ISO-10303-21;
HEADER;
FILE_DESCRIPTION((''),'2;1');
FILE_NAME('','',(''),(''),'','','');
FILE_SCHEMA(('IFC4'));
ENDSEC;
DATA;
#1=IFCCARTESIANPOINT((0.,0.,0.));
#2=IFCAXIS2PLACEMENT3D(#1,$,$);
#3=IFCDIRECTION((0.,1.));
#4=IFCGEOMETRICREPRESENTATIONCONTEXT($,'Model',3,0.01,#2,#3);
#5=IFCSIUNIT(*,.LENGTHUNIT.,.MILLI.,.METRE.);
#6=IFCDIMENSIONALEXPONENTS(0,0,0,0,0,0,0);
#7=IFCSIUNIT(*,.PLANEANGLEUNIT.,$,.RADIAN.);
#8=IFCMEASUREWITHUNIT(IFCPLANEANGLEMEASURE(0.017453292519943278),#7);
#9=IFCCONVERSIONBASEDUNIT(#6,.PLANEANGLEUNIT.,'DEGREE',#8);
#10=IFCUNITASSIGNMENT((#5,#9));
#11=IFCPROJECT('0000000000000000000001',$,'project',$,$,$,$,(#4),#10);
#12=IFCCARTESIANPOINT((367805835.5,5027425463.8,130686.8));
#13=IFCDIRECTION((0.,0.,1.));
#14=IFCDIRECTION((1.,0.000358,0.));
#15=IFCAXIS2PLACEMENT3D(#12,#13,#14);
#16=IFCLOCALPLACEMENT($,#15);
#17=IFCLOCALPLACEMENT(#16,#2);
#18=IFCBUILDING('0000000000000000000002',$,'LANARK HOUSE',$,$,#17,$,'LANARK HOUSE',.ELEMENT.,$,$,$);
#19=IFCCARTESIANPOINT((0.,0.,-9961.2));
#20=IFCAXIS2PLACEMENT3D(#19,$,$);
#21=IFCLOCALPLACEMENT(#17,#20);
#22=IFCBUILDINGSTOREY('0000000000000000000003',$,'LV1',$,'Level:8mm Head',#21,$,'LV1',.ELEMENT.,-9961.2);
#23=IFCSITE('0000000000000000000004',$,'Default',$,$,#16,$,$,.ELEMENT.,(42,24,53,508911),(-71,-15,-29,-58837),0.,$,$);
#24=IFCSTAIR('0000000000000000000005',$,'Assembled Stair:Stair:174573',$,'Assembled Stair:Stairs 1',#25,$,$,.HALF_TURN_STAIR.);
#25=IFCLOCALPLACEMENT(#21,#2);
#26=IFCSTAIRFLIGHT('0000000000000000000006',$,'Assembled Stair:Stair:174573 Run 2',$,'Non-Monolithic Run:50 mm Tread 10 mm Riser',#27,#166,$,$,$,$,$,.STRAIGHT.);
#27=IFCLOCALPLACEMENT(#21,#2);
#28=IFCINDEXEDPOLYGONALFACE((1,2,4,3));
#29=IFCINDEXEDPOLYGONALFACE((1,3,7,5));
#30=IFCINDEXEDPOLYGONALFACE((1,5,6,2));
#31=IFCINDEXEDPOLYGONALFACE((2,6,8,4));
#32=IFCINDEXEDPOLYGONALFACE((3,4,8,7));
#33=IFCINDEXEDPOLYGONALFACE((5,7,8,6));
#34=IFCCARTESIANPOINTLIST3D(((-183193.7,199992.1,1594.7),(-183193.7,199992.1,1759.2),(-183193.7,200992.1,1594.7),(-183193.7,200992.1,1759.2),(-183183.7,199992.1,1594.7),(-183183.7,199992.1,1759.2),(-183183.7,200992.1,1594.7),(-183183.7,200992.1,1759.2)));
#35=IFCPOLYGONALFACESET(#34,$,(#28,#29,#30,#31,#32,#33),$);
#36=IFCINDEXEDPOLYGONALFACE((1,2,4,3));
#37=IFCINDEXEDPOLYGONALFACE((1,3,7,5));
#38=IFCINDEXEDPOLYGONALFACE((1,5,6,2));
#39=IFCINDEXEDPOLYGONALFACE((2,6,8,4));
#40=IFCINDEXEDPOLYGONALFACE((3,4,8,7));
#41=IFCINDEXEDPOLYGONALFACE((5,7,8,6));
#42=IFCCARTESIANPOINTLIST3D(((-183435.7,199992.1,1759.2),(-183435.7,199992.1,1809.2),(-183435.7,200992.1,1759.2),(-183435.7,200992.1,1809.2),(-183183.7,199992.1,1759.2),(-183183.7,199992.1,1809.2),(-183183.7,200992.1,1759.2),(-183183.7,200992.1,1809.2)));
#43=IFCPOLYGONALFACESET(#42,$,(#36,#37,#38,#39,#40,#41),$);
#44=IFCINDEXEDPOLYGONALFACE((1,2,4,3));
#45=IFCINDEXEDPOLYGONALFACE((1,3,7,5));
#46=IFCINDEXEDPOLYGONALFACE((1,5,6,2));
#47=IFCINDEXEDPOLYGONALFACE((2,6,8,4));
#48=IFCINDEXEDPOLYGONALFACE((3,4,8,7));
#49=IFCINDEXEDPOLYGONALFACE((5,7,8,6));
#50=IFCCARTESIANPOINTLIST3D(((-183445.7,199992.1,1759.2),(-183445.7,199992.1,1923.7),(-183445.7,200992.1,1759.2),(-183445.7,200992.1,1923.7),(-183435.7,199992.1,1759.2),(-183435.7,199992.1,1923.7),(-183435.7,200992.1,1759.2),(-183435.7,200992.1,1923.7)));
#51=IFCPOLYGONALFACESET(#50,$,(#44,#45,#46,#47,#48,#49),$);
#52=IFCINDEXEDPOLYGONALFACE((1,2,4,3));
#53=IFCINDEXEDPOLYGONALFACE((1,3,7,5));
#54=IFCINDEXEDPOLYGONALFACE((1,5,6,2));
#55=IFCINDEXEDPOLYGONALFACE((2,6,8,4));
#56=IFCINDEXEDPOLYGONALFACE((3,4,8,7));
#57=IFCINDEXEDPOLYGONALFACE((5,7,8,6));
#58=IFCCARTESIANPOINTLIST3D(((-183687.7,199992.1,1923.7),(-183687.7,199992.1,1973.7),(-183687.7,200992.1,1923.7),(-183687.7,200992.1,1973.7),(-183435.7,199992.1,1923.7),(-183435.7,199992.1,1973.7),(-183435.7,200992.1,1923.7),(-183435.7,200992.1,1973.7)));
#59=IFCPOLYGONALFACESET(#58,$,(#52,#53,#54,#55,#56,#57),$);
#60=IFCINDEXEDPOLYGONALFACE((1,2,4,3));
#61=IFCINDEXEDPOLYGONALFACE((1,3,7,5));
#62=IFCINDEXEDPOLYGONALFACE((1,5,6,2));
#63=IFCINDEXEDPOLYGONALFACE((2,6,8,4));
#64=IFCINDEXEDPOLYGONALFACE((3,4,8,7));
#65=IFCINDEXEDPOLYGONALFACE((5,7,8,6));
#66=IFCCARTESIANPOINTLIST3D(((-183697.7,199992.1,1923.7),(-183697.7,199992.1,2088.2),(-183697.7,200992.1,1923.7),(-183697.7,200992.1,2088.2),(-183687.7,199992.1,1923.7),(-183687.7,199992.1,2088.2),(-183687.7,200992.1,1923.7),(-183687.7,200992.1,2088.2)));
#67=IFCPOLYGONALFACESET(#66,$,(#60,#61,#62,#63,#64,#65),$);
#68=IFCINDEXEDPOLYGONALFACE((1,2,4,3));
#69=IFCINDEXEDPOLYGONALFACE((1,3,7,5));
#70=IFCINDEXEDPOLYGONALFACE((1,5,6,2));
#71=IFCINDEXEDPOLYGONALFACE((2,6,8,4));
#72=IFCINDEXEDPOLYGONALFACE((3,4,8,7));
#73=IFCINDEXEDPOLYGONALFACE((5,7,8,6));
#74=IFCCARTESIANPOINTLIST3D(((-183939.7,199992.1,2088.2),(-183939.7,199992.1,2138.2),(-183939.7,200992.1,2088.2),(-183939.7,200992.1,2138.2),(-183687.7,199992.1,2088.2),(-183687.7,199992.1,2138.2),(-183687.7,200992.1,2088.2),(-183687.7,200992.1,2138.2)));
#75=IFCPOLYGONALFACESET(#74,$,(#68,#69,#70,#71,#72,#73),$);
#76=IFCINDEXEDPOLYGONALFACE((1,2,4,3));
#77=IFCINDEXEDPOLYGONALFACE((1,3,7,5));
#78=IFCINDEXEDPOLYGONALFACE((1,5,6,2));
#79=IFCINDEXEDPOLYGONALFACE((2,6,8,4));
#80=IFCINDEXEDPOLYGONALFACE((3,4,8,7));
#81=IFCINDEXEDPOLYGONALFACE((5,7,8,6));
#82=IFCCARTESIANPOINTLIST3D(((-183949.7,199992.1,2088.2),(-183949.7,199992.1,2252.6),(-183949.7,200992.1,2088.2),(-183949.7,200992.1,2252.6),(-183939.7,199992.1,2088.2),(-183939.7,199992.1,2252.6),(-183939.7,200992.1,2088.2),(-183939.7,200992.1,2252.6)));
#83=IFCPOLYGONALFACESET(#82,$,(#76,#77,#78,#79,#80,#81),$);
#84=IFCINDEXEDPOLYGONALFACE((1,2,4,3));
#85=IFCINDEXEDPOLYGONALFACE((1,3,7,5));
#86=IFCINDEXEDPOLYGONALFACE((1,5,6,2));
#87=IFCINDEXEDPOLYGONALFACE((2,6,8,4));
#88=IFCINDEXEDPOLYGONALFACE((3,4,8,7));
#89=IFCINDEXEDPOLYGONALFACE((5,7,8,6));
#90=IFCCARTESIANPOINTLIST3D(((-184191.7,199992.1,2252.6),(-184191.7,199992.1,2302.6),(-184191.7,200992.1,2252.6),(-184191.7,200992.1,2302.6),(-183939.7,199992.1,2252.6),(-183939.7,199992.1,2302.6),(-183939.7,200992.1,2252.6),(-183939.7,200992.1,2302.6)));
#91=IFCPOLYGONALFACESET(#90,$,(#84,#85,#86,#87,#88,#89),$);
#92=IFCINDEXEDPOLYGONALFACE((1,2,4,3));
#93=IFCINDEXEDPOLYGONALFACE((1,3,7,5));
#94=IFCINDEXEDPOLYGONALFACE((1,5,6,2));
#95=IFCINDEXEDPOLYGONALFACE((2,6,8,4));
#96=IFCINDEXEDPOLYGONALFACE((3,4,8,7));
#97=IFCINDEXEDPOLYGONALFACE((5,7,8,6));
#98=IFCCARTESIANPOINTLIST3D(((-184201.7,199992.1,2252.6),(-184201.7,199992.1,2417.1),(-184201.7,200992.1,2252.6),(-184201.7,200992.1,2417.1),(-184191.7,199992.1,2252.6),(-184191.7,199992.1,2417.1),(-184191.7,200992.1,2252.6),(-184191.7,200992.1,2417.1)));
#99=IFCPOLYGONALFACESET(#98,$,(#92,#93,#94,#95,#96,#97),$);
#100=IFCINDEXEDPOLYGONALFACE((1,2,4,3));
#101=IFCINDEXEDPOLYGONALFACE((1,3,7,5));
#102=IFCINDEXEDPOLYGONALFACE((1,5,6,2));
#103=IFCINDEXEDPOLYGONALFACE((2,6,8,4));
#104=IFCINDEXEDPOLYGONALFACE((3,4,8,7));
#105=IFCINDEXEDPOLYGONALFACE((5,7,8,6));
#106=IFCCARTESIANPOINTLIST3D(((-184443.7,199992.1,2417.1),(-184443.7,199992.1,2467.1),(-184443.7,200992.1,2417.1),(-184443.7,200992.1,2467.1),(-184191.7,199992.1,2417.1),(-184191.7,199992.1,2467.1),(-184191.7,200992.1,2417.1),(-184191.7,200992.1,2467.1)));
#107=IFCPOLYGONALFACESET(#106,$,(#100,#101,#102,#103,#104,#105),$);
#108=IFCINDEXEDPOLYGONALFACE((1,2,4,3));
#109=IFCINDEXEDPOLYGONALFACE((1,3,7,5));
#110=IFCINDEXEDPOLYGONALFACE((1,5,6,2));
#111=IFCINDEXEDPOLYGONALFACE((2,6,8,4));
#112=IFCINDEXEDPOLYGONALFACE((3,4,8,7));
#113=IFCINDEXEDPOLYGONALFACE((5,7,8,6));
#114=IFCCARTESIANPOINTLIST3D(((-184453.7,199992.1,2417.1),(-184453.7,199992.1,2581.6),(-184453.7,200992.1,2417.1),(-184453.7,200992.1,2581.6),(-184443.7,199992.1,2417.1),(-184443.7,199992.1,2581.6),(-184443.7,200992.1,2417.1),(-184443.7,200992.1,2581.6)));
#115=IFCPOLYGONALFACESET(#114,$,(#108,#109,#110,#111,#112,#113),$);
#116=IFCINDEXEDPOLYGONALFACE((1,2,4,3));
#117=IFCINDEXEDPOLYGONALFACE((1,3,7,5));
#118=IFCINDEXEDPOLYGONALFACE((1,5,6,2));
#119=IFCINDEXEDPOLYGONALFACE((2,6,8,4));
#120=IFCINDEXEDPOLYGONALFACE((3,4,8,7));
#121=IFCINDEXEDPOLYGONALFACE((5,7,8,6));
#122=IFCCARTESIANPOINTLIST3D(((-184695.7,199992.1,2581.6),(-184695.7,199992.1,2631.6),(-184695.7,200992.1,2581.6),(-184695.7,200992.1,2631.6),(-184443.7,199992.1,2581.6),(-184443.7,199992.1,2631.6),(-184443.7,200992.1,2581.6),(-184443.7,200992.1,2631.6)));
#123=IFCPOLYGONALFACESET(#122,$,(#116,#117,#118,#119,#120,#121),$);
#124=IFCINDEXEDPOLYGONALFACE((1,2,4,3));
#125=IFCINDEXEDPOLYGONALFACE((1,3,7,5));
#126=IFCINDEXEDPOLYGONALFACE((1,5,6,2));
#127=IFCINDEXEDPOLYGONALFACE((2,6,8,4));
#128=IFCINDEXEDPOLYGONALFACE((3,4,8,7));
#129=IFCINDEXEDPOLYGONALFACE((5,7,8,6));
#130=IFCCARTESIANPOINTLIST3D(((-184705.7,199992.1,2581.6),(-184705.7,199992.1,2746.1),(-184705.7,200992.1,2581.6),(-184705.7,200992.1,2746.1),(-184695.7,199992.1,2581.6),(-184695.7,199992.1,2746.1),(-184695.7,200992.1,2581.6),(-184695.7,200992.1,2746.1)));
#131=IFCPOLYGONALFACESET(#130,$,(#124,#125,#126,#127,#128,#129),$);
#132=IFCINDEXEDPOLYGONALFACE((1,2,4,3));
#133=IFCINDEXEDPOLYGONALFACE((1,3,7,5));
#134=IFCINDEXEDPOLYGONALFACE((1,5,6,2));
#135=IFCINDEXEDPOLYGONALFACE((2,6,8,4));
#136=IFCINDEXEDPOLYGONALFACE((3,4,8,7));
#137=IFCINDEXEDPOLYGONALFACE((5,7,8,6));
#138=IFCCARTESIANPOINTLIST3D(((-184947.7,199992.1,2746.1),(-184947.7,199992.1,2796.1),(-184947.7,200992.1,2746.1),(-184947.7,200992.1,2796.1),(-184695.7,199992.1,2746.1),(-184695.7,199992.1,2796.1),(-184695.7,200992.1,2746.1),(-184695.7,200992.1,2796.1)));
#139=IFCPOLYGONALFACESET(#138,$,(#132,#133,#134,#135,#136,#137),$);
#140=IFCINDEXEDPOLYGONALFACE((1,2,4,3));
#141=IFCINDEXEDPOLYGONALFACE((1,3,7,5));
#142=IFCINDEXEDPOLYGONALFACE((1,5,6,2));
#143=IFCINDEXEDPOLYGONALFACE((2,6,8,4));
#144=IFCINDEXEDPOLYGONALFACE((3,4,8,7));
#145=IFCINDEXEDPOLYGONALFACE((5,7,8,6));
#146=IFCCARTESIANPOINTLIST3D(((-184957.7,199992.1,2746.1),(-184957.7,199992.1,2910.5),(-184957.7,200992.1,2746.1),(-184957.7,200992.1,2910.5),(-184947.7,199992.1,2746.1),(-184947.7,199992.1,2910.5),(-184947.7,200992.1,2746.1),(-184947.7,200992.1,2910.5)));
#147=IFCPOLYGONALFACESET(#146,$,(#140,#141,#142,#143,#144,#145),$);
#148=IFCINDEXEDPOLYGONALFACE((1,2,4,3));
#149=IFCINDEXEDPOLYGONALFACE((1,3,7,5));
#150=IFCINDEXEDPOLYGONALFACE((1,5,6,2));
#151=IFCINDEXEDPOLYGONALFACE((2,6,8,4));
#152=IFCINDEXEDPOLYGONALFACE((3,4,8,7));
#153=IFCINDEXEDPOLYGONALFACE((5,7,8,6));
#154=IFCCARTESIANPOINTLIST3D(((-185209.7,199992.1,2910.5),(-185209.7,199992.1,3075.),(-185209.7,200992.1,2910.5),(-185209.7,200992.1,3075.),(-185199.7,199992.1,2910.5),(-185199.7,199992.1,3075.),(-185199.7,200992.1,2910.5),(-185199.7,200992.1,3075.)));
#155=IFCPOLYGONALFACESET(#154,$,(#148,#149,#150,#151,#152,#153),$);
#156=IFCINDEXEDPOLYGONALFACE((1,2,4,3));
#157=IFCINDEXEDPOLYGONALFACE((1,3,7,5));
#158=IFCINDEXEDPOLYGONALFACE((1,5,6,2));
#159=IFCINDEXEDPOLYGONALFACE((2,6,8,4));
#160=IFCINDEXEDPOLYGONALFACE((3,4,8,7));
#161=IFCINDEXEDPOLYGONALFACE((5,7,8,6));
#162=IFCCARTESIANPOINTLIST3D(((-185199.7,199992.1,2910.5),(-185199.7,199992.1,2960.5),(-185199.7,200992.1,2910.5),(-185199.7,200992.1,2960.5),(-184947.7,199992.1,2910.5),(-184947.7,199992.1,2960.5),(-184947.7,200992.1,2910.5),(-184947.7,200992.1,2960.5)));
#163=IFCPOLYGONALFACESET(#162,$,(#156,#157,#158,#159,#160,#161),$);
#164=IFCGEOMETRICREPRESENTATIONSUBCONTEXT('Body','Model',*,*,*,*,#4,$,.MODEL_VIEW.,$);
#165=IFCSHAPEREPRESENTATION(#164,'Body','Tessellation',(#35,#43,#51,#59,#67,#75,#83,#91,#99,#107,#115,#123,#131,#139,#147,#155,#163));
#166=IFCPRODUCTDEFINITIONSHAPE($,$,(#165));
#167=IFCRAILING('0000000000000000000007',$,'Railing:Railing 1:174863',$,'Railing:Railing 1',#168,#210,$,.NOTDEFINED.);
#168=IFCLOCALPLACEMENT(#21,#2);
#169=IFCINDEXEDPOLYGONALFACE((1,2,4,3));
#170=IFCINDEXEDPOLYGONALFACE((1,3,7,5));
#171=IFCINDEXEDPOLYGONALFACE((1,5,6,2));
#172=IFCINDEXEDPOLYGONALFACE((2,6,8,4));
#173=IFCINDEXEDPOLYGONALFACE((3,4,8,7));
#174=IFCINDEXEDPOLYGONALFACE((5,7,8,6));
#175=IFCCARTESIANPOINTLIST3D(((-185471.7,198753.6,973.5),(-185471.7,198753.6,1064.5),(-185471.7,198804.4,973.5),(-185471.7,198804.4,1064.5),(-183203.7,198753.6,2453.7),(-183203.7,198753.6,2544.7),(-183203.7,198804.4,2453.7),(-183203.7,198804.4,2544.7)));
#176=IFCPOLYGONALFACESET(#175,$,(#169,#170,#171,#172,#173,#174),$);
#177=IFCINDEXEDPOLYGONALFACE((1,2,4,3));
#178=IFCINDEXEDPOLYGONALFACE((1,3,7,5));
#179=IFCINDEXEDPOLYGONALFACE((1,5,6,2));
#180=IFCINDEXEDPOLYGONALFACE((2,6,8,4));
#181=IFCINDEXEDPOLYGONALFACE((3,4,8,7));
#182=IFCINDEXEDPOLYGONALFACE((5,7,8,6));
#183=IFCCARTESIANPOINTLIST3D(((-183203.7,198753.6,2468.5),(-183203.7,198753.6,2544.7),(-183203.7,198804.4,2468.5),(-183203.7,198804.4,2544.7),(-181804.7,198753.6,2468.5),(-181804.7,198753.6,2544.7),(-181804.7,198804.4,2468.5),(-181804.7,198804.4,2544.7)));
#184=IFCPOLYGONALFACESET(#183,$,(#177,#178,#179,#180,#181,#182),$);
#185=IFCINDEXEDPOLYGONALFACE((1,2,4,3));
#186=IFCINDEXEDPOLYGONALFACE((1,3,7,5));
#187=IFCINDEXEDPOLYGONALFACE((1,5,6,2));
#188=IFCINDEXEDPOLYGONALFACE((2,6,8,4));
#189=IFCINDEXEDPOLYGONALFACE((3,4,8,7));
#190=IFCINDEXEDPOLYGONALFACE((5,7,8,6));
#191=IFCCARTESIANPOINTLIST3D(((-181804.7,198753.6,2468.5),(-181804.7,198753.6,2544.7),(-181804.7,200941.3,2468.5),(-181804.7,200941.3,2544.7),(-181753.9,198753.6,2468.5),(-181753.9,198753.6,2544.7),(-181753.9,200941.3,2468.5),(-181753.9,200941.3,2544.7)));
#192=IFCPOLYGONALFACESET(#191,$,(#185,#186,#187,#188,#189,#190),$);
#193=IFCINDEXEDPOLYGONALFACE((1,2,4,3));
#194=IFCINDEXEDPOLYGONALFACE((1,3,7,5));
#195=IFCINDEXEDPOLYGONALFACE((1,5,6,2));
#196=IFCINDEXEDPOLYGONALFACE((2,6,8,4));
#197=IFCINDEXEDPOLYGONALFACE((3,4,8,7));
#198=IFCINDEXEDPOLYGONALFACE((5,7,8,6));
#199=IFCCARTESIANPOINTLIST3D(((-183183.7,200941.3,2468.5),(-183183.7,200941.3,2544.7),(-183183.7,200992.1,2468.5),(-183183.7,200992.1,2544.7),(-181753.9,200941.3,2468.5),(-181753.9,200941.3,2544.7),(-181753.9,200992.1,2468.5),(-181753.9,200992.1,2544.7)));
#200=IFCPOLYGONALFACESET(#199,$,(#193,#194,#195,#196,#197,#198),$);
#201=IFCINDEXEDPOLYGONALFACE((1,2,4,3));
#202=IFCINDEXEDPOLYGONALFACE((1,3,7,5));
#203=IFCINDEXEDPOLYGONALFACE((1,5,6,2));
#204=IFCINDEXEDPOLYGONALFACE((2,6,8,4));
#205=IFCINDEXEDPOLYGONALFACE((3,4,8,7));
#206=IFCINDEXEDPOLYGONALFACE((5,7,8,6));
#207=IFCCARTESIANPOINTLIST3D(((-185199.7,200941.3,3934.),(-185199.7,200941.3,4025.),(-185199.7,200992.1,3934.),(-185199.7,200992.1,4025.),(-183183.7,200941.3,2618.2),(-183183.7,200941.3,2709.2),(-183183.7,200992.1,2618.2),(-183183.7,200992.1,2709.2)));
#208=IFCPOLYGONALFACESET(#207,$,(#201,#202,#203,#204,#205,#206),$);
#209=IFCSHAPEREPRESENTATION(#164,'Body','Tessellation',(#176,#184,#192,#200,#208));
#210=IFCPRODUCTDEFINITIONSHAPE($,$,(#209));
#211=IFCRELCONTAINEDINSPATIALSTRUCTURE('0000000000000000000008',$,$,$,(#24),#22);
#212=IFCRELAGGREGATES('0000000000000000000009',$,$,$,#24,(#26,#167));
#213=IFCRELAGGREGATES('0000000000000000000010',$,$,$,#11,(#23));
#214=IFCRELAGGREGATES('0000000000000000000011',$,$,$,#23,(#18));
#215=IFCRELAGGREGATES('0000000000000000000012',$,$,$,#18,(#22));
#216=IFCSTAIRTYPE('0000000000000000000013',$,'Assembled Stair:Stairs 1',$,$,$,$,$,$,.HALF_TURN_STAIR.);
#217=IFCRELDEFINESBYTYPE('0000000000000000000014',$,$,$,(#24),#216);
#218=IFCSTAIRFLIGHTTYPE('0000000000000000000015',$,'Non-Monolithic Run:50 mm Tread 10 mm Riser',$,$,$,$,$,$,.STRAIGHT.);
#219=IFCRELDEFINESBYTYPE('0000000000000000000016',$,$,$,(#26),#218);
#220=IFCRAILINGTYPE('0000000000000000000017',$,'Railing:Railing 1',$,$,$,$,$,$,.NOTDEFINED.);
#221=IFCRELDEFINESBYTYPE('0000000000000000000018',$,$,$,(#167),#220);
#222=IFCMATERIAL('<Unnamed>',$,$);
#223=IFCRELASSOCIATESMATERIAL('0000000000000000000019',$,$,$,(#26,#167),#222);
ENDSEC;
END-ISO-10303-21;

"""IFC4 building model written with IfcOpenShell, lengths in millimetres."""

from ifc_helpers import new_model, entity, si_unit, converted_unit, direction, frame, origin, place, context, subcontext, project, spatial, indexed_curve, outline, extrude, material, type_object, element, aggregate, save


model = new_model("IFC4")

# Units and contexts
model_context = context("Model", 3, precision=0.01, world=origin(), true_north=direction((0.0, 1.0)))
body_context = subcontext(model_context, "Body", "Model", "MODEL_VIEW")
ifc_project = project(units=[si_unit("LENGTHUNIT", "METRE", prefix="MILLI"), converted_unit("PLANEANGLEUNIT", "DEGREE", entity("IfcPlaneAngleMeasure", 0.017453292519943278), si_unit("PLANEANGLEUNIT", "RADIAN"), dimensions=[0, 0, 0, 0, 0, 0, 0])], contexts=[model_context])

# Site, building, storey
site_placement = place(None, frame((367805835.5, 5027425463.8, 130686.8), z_axis=(0.0, 0.0, 1.0), x_axis=(1.0, 0.000358, 0.0)))
site = spatial("IfcSite", under=ifc_project, at=site_placement, Name="Default", CompositionType="ELEMENT", RefLatitude=(42, 24, 53, 508911), RefLongitude=(-71, -15, -29, -58837), RefElevation=0.0)
building_placement = place(site_placement, origin())
building = spatial("IfcBuilding", under=site, at=building_placement, Name="LANARK HOUSE", LongName="LANARK HOUSE", CompositionType="ELEMENT")
storey_placement = place(building_placement, frame((0.0, 0.0, -9961.2)))
storey = spatial("IfcBuildingStorey", under=building, at=storey_placement, Name="LV1", ObjectType="Level:8mm Head", LongName="LV1", CompositionType="ELEMENT", Elevation=-9961.2)

# Stair
stair_type = type_object("IfcStairType", Name="Assembled Stair:Stairs 1", PredefinedType="HALF_TURN_STAIR")
stair_placement = place(storey_placement, origin())
stair = element("IfcStair", 1, at=stair_placement, inside=storey, type_object=stair_type, Name="Assembled Stair:Stair:174573", ObjectType="Assembled Stair:Stairs 1", PredefinedType="HALF_TURN_STAIR")
ifc_material_1 = material(Name="<Unnamed>")

# Stair flight
stair_flight_type = type_object("IfcStairFlightType", Name="Non-Monolithic Run:50 mm Tread 10 mm Riser", PredefinedType="STRAIGHT")
stair_flight_1_placement = place(stair_placement, frame((-185209.7, 199992.1, 0.0)))
stair_flight_1 = element("IfcStairFlight", 2, at=stair_flight_1_placement, type_object=stair_flight_type, material=ifc_material_1, Name="Assembled Stair:Stair:174573 Run 2", ObjectType="Non-Monolithic Run:50 mm Tread 10 mm Riser", PredefinedType="STRAIGHT", context=body_context, shape_type="SweptSolid", body=[
    extrude(outline(indexed_curve([(-500.0, -5.0), (500.0, -5.0), (500.0, 5.0), (-500.0, 5.0), (-500.0, -5.0)], self_intersect=False)), frame((2021.0, 500.0, 1594.7), z_axis=(0.0, 0.0, 1.0), x_axis=(0.0, -1.0, 0.0)), (0.0, 0.0, 1.0), 164.5),
    extrude(outline(indexed_curve([(-126.0, -500.0), (126.0, -500.0), (126.0, 500.0), (-126.0, 500.0), (-126.0, -500.0)], self_intersect=False)), frame((1900.0, 500.0, 1759.2)), (0.0, 0.0, 1.0), 50.0),
    extrude(outline(indexed_curve([(-500.0, -5.0), (500.0, -5.0), (500.0, 5.0), (-500.0, 5.0), (-500.0, -5.0)], self_intersect=False)), frame((1769.0, 500.0, 1759.2), z_axis=(0.0, 0.0, 1.0), x_axis=(0.0, -1.0, 0.0)), (0.0, 0.0, 1.0), 164.5),
    extrude(outline(indexed_curve([(-126.0, -500.0), (126.0, -500.0), (126.0, 500.0), (-126.0, 500.0), (-126.0, -500.0)], self_intersect=False)), frame((1648.0, 500.0, 1923.7)), (0.0, 0.0, 1.0), 50.0),
    extrude(outline(indexed_curve([(-500.0, -5.0), (500.0, -5.0), (500.0, 5.0), (-500.0, 5.0), (-500.0, -5.0)], self_intersect=False)), frame((1517.0, 500.0, 1923.7), z_axis=(0.0, 0.0, 1.0), x_axis=(0.0, -1.0, 0.0)), (0.0, 0.0, 1.0), 164.5),
    extrude(outline(indexed_curve([(-126.0, -500.0), (126.0, -500.0), (126.0, 500.0), (-126.0, 500.0), (-126.0, -500.0)], self_intersect=False)), frame((1396.0, 500.0, 2088.2)), (0.0, 0.0, 1.0), 50.0),
    extrude(outline(indexed_curve([(-500.0, -5.0), (500.0, -5.0), (500.0, 5.0), (-500.0, 5.0), (-500.0, -5.0)], self_intersect=False)), frame((1265.0, 500.0, 2088.2), z_axis=(0.0, 0.0, 1.0), x_axis=(0.0, -1.0, 0.0)), (0.0, 0.0, 1.0), 164.5),
    extrude(outline(indexed_curve([(-126.0, -500.0), (126.0, -500.0), (126.0, 500.0), (-126.0, 500.0), (-126.0, -500.0)], self_intersect=False)), frame((1144.0, 500.0, 2252.6)), (0.0, 0.0, 1.0), 50.0),
    extrude(outline(indexed_curve([(-500.0, -5.0), (500.0, -5.0), (500.0, 5.0), (-500.0, 5.0), (-500.0, -5.0)], self_intersect=False)), frame((1013.0, 500.0, 2252.6), z_axis=(0.0, 0.0, 1.0), x_axis=(0.0, -1.0, 0.0)), (0.0, 0.0, 1.0), 164.5),
    extrude(outline(indexed_curve([(-126.0, -500.0), (126.0, -500.0), (126.0, 500.0), (-126.0, 500.0), (-126.0, -500.0)], self_intersect=False)), frame((892.0, 500.0, 2417.1)), (0.0, 0.0, 1.0), 50.0),
    extrude(outline(indexed_curve([(-500.0, -5.0), (500.0, -5.0), (500.0, 5.0), (-500.0, 5.0), (-500.0, -5.0)], self_intersect=False)), frame((761.0, 500.0, 2417.1), z_axis=(0.0, 0.0, 1.0), x_axis=(0.0, -1.0, 0.0)), (0.0, 0.0, 1.0), 164.5),
    extrude(outline(indexed_curve([(-126.0, -500.0), (126.0, -500.0), (126.0, 500.0), (-126.0, 500.0), (-126.0, -500.0)], self_intersect=False)), frame((640.0, 500.0, 2581.6)), (0.0, 0.0, 1.0), 50.0),
    extrude(outline(indexed_curve([(-500.0, -5.0), (500.0, -5.0), (500.0, 5.0), (-500.0, 5.0), (-500.0, -5.0)], self_intersect=False)), frame((509.0, 500.0, 2581.6), z_axis=(0.0, 0.0, 1.0), x_axis=(0.0, -1.0, 0.0)), (0.0, 0.0, 1.0), 164.5),
    extrude(outline(indexed_curve([(-126.0, -500.0), (126.0, -500.0), (126.0, 500.0), (-126.0, 500.0), (-126.0, -500.0)], self_intersect=False)), frame((388.0, 500.0, 2746.1)), (0.0, 0.0, 1.0), 50.0),
    extrude(outline(indexed_curve([(-500.0, -5.0), (500.0, -5.0), (500.0, 5.0), (-500.0, 5.0), (-500.0, -5.0)], self_intersect=False)), frame((257.0, 500.0, 2746.1), z_axis=(0.0, 0.0, 1.0), x_axis=(0.0, -1.0, 0.0)), (0.0, 0.0, 1.0), 164.5),
    extrude(outline(indexed_curve([(-500.0, -5.0), (500.0, -5.0), (500.0, 5.0), (-500.0, 5.0), (-500.0, -5.0)], self_intersect=False)), frame((5.0, 500.0, 2910.5), z_axis=(0.0, 0.0, 1.0), x_axis=(0.0, -1.0, 0.0)), (0.0, 0.0, 1.0), 164.5),
    extrude(outline(indexed_curve([(-126.0, -500.0), (126.0, -500.0), (126.0, 500.0), (-126.0, 500.0), (-126.0, -500.0)], self_intersect=False)), frame((136.0, 500.0, 2910.5)), (0.0, 0.0, 1.0), 50.0),
])

# Railing
railing_type = type_object("IfcRailingType", Name="Railing:Railing 1", PredefinedType="NOTDEFINED")
railing_1_placement = place(stair_placement, frame((-185471.7, 198753.6, 973.5)))
railing_1 = element("IfcRailing", 3, at=railing_1_placement, type_object=railing_type, material=ifc_material_1, Name="Railing:Railing 1:174863", ObjectType="Railing:Railing 1", PredefinedType="NOTDEFINED", context=body_context, shape_type="SweptSolid", body=[
    extrude(outline(indexed_curve([(-1329.3, -38.1), (1379.0, -38.1), (1329.3, 38.1), (-1379.0, 38.1), (-1329.3, -38.1)], self_intersect=False)), frame((1134.0, 0.0, 785.6), z_axis=(0.0, 1.0, 0.0), x_axis=(0.837419, 0.0, 0.546561)), (0.0, 0.0, 1.0), 50.8),
    extrude(outline(indexed_curve([(-699.5, -25.4), (699.5, -25.4), (699.5, 25.4), (-699.5, 25.4), (-699.5, -25.4)], self_intersect=False)), frame((2967.5, 25.4, 1495.1)), (0.0, 0.0, 1.0), 76.2),
    extrude(outline(indexed_curve([(-1093.8, -25.4), (1093.8, -25.4), (1093.8, 25.4), (-1093.8, 25.4), (-1093.8, -25.4)], self_intersect=False)), frame((3692.4, 1093.8, 1495.1), z_axis=(0.0, 0.0, 1.0), x_axis=(0.0, 1.0, 0.0)), (0.0, 0.0, 1.0), 76.2),
    extrude(outline(indexed_curve([(-714.9, -25.4), (714.9, -25.4), (714.9, 25.4), (-714.9, 25.4), (-714.9, -25.4)], self_intersect=False)), frame((3002.9, 2213.0, 1495.1), z_axis=(0.0, 0.0, 1.0), x_axis=(-1.0, 0.0, 0.0)), (0.0, 0.0, 1.0), 76.2),
    extrude(outline(indexed_curve([(-1228.6, -38.1), (1178.8, -38.1), (1228.6, 38.1), (-1178.8, 38.1), (-1228.6, -38.1)], self_intersect=False)), frame((1280.0, 2187.6, 2348.1), z_axis=(0.0, 1.0, 0.0), x_axis=(-0.837419, 0.0, 0.546561)), (0.0, 0.0, 1.0), 50.8),
])
aggregate(stair, [stair_flight_1, railing_1])

save(model, "model.ifc")
